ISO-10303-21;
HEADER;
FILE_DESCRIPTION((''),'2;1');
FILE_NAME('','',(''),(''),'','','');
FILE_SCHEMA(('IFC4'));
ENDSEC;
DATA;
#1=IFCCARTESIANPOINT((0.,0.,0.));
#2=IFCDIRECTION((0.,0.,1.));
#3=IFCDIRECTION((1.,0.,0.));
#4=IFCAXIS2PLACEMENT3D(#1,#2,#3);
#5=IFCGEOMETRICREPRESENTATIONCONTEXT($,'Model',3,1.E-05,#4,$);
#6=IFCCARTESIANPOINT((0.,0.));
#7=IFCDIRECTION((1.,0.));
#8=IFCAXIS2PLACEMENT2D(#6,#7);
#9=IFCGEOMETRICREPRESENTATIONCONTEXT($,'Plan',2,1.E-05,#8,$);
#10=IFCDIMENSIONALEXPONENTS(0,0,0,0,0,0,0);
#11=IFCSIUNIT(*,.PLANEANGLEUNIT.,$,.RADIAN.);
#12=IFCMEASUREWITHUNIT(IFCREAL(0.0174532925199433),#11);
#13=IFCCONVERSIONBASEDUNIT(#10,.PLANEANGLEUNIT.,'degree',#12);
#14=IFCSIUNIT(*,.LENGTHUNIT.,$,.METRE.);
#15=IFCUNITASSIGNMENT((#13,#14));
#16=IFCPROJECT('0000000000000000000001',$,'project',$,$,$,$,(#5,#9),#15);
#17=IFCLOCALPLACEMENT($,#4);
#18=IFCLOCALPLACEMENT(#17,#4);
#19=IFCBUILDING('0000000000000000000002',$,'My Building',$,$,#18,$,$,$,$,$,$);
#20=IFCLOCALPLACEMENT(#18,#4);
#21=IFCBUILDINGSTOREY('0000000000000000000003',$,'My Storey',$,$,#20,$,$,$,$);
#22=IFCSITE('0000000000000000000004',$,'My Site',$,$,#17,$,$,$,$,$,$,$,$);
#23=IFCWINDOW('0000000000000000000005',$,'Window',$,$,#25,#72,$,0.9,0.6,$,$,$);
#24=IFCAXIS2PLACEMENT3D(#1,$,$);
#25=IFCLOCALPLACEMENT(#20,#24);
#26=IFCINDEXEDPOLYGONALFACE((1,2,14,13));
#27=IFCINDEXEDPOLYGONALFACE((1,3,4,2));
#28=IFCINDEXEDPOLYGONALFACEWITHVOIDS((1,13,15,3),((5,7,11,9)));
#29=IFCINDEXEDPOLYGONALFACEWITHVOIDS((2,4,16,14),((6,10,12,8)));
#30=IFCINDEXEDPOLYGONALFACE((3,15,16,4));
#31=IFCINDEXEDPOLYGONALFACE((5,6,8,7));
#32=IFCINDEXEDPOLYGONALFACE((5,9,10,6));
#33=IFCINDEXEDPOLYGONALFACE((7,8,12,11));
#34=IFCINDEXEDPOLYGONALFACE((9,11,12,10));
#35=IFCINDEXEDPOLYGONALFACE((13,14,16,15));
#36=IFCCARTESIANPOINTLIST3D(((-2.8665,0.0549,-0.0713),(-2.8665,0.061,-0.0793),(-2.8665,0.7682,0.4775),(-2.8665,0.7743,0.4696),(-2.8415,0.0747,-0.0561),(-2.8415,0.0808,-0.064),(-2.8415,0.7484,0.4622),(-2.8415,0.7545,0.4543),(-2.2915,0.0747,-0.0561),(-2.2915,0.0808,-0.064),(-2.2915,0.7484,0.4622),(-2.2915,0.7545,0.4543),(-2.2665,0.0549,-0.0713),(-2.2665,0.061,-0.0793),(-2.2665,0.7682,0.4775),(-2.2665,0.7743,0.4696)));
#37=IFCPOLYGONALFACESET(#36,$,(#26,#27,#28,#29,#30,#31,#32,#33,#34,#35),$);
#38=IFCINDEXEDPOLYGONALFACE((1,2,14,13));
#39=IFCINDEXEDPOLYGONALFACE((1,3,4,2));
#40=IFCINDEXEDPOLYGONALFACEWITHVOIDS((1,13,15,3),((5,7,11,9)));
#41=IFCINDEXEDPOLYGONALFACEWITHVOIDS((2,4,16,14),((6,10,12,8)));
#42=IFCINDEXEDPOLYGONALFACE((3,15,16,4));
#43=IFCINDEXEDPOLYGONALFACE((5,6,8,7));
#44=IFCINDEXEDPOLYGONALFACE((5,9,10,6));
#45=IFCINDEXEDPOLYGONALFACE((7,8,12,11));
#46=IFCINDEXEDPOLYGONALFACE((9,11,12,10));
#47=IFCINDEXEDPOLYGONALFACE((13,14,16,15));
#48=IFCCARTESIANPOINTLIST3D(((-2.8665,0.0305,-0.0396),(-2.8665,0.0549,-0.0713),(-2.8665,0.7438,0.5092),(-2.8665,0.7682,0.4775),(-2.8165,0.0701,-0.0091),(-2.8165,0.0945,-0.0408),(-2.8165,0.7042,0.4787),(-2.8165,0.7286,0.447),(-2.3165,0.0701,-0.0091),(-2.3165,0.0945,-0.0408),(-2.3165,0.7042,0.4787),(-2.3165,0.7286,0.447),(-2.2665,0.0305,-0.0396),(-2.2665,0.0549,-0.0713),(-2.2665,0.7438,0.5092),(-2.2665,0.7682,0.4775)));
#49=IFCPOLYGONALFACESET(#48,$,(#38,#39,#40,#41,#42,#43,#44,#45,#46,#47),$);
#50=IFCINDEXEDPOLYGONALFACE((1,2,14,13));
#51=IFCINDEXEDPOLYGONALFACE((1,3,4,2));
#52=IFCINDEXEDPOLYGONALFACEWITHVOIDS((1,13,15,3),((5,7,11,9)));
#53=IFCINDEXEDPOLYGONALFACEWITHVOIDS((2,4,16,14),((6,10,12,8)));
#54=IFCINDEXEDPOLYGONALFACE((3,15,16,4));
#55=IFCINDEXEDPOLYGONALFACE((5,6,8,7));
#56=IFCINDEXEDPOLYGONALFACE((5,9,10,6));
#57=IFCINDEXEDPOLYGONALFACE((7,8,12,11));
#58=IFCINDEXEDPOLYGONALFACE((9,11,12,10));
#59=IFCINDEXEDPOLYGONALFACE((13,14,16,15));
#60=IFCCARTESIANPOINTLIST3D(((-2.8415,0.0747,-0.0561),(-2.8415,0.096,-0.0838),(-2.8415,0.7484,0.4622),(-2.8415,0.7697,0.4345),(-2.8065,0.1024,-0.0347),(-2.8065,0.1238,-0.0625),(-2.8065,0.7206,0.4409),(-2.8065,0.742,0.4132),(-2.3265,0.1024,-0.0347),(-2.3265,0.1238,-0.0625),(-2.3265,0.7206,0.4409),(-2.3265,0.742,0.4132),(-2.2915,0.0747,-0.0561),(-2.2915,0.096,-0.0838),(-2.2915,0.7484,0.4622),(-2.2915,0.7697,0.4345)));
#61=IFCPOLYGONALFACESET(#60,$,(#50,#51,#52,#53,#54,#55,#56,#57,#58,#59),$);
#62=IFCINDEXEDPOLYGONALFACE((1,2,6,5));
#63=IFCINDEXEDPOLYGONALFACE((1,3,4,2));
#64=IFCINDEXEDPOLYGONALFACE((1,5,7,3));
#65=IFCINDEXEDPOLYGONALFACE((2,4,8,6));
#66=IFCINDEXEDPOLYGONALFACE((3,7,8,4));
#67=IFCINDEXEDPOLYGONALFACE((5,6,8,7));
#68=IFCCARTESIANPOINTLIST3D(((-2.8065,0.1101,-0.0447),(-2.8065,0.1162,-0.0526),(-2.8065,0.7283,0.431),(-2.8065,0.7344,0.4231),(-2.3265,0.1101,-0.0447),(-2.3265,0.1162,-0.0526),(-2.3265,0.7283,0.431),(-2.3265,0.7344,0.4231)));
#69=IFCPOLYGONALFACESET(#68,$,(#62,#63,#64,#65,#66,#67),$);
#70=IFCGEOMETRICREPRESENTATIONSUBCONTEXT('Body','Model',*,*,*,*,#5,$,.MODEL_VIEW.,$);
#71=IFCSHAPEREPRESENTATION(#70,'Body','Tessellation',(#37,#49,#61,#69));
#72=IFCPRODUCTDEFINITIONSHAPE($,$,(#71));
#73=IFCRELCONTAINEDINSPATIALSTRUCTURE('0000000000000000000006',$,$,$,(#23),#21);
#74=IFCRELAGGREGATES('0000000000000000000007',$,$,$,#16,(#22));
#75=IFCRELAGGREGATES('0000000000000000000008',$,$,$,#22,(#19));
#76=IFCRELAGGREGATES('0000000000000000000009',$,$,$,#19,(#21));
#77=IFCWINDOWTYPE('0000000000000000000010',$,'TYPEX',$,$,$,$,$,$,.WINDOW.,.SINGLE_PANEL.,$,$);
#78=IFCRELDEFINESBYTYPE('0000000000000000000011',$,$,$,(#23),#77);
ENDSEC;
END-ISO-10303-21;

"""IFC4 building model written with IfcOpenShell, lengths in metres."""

from ifc_helpers import new_model, entity, si_unit, converted_unit, frame, origin_with_axes, origin_2d_with_axis, place, context, subcontext, project, spatial, line, indexed_curve, outline, extrude, shape, source, transform, mapped, type_object, type_shapes, element, save


model = new_model("IFC4")

# Units and contexts
model_context = context("Model", 3, precision=1e-05, world=origin_with_axes())
plan_context = context("Plan", 2, precision=1e-05, world=origin_2d_with_axis())
body_context_1 = subcontext(model_context, "Body", "Model", "MODEL_VIEW")
body_context_2 = subcontext(plan_context, "Body", "Plan", "PLAN_VIEW")
ifc_project = project(units=[converted_unit("PLANEANGLEUNIT", "degree", entity("IfcReal", 0.0174532925199433), si_unit("PLANEANGLEUNIT", "RADIAN"), dimensions=[0, 0, 0, 0, 0, 0, 0]), si_unit("LENGTHUNIT", "METRE")], contexts=[model_context, plan_context])

# Site, building, storey
site_placement = place(None, origin_with_axes())
site = spatial("IfcSite", under=ifc_project, at=site_placement, Name="My Site")
building_placement = place(site_placement, origin_with_axes())
building = spatial("IfcBuilding", under=site, at=building_placement, Name="My Building")
storey_placement = place(building_placement, origin_with_axes())
storey = spatial("IfcBuildingStorey", under=building, at=storey_placement, Name="My Storey")

# Window
window_type = type_object("IfcWindowType", Name="TYPEX", PartitioningType="SINGLE_PANEL", PredefinedType="WINDOW")
shared_shape_1 = source(origin_with_axes(), body_context_1, "Body", "SweptSolid", [
    extrude(outline(indexed_curve([(0.0, 0.0), (0.6, 0.0), (0.6, 0.9), (0.0, 0.9)], segments=[line(1, 2, 3, 4, 1)]), holes=[indexed_curve([(0.025, 0.025), (0.575, 0.025), (0.575, 0.875), (0.025, 0.875)], segments=[line(1, 2, 3, 4, 1)])]), frame((0.0, 0.09, 0.0), z_axis=(0.0, -1.0, 0.0), x_axis=(1.0, 0.0, 0.0)), (0.0, 0.0, -1.0), 0.01),
    extrude(outline(indexed_curve([(0.0, 0.0), (0.6, 0.0), (0.6, 0.9), (0.0, 0.9)], segments=[line(1, 2, 3, 4, 1)]), holes=[indexed_curve([(0.05, 0.05), (0.55, 0.05), (0.55, 0.85), (0.05, 0.85)], segments=[line(1, 2, 3, 4, 1)])]), frame((0.0, 0.05, 0.0), z_axis=(0.0, -1.0, 0.0), x_axis=(1.0, 0.0, 0.0)), (0.0, 0.0, -1.0), 0.04),
    extrude(outline(indexed_curve([(0.0, 0.0), (0.55, 0.0), (0.55, 0.85), (0.0, 0.85)], segments=[line(1, 2, 3, 4, 1)]), holes=[indexed_curve([(0.035, 0.035), (0.515, 0.035), (0.515, 0.815), (0.035, 0.815)], segments=[line(1, 2, 3, 4, 1)])]), frame((0.025, 0.09, 0.025), z_axis=(0.0, -1.0, 0.0), x_axis=(1.0, 0.0, 0.0)), (0.0, 0.0, -1.0), 0.035),
    extrude(outline(indexed_curve([(0.035, 0.035), (0.515, 0.035), (0.515, 0.815), (0.035, 0.815)], segments=[line(1, 2, 3, 4, 1)])), frame((0.025, 0.1025, 0.025), z_axis=(0.0, -1.0, 0.0), x_axis=(1.0, 0.0, 0.0)), (0.0, 0.0, -1.0), 0.01),
])
shared_shape_2 = source(origin_with_axes(), body_context_2, "Body", "Curve2D", [
    entity("IfcIndexedPolyCurve", entity("IfcCartesianPointList2D", [[0.05, 0.05], [0.55, 0.05]])),
    entity("IfcIndexedPolyCurve", entity("IfcCartesianPointList2D", [[0.0, 0.1], [0.025, 0.1], [0.025, 0.09], [0.05, 0.09], [0.05, 0.05], [0.0, 0.05]]), [entity("IfcLineIndex", [1, 2, 3, 4, 5, 6, 1])]),
    entity("IfcIndexedPolyCurve", entity("IfcCartesianPointList2D", [[0.6, 0.1], [0.575, 0.1], [0.575, 0.09], [0.55, 0.09], [0.55, 0.05], [0.6, 0.05]]), [entity("IfcLineIndex", [1, 2, 3, 4, 5, 6, 1])]),
    entity("IfcIndexedPolyCurve", entity("IfcCartesianPointList2D", [[0.025, 0.09], [0.06, 0.09], [0.06, 0.125], [0.025, 0.125]]), [entity("IfcLineIndex", [1, 2, 3, 4, 1])]),
    entity("IfcIndexedPolyCurve", entity("IfcCartesianPointList2D", [[0.575, 0.09], [0.54, 0.09], [0.54, 0.125], [0.575, 0.125]]), [entity("IfcLineIndex", [1, 2, 3, 4, 1])]),
    entity("IfcIndexedPolyCurve", entity("IfcCartesianPointList2D", [[0.06, 0.09], [0.54, 0.09]])),
    entity("IfcIndexedPolyCurve", entity("IfcCartesianPointList2D", [[0.06, 0.125], [0.54, 0.125]])),
    entity("IfcIndexedPolyCurve", entity("IfcCartesianPointList2D", [[0.06, 0.1075], [0.54, 0.1075]])),
])
type_shapes(window_type, [shared_shape_1, shared_shape_2])
for number, where, z_axis, x_axis, name in (
    (1, (-2.8665, 0.0, 0.0), (0.0, 0.792564, 0.609788), (1.0, 0.0, 0.0), "Window"),
):
    element("IfcWindow", number, at=place(storey_placement, frame(where, z_axis=z_axis, x_axis=x_axis)), inside=storey, type_object=window_type, Name=name, OverallHeight=0.9, OverallWidth=0.6, shapes=[
        shape(body_context_1, "Body", "MappedRepresentation", [mapped(shared_shape_1, transform((0.0, 0.0, 0.0), x_axis=(1.0, 0.0, 0.0), y_axis=(0.0, 1.0, 0.0), z_axis=(0.0, 0.0, 1.0), scale=1.0))]),
        shape(body_context_2, "Body", "MappedRepresentation", [mapped(shared_shape_2, transform((0.0, 0.0, 0.0), x_axis=(1.0, 0.0, 0.0), y_axis=(0.0, 1.0, 0.0), z_axis=(0.0, 0.0, 1.0), scale=1.0))]),
    ])

save(model, "model.ifc")
